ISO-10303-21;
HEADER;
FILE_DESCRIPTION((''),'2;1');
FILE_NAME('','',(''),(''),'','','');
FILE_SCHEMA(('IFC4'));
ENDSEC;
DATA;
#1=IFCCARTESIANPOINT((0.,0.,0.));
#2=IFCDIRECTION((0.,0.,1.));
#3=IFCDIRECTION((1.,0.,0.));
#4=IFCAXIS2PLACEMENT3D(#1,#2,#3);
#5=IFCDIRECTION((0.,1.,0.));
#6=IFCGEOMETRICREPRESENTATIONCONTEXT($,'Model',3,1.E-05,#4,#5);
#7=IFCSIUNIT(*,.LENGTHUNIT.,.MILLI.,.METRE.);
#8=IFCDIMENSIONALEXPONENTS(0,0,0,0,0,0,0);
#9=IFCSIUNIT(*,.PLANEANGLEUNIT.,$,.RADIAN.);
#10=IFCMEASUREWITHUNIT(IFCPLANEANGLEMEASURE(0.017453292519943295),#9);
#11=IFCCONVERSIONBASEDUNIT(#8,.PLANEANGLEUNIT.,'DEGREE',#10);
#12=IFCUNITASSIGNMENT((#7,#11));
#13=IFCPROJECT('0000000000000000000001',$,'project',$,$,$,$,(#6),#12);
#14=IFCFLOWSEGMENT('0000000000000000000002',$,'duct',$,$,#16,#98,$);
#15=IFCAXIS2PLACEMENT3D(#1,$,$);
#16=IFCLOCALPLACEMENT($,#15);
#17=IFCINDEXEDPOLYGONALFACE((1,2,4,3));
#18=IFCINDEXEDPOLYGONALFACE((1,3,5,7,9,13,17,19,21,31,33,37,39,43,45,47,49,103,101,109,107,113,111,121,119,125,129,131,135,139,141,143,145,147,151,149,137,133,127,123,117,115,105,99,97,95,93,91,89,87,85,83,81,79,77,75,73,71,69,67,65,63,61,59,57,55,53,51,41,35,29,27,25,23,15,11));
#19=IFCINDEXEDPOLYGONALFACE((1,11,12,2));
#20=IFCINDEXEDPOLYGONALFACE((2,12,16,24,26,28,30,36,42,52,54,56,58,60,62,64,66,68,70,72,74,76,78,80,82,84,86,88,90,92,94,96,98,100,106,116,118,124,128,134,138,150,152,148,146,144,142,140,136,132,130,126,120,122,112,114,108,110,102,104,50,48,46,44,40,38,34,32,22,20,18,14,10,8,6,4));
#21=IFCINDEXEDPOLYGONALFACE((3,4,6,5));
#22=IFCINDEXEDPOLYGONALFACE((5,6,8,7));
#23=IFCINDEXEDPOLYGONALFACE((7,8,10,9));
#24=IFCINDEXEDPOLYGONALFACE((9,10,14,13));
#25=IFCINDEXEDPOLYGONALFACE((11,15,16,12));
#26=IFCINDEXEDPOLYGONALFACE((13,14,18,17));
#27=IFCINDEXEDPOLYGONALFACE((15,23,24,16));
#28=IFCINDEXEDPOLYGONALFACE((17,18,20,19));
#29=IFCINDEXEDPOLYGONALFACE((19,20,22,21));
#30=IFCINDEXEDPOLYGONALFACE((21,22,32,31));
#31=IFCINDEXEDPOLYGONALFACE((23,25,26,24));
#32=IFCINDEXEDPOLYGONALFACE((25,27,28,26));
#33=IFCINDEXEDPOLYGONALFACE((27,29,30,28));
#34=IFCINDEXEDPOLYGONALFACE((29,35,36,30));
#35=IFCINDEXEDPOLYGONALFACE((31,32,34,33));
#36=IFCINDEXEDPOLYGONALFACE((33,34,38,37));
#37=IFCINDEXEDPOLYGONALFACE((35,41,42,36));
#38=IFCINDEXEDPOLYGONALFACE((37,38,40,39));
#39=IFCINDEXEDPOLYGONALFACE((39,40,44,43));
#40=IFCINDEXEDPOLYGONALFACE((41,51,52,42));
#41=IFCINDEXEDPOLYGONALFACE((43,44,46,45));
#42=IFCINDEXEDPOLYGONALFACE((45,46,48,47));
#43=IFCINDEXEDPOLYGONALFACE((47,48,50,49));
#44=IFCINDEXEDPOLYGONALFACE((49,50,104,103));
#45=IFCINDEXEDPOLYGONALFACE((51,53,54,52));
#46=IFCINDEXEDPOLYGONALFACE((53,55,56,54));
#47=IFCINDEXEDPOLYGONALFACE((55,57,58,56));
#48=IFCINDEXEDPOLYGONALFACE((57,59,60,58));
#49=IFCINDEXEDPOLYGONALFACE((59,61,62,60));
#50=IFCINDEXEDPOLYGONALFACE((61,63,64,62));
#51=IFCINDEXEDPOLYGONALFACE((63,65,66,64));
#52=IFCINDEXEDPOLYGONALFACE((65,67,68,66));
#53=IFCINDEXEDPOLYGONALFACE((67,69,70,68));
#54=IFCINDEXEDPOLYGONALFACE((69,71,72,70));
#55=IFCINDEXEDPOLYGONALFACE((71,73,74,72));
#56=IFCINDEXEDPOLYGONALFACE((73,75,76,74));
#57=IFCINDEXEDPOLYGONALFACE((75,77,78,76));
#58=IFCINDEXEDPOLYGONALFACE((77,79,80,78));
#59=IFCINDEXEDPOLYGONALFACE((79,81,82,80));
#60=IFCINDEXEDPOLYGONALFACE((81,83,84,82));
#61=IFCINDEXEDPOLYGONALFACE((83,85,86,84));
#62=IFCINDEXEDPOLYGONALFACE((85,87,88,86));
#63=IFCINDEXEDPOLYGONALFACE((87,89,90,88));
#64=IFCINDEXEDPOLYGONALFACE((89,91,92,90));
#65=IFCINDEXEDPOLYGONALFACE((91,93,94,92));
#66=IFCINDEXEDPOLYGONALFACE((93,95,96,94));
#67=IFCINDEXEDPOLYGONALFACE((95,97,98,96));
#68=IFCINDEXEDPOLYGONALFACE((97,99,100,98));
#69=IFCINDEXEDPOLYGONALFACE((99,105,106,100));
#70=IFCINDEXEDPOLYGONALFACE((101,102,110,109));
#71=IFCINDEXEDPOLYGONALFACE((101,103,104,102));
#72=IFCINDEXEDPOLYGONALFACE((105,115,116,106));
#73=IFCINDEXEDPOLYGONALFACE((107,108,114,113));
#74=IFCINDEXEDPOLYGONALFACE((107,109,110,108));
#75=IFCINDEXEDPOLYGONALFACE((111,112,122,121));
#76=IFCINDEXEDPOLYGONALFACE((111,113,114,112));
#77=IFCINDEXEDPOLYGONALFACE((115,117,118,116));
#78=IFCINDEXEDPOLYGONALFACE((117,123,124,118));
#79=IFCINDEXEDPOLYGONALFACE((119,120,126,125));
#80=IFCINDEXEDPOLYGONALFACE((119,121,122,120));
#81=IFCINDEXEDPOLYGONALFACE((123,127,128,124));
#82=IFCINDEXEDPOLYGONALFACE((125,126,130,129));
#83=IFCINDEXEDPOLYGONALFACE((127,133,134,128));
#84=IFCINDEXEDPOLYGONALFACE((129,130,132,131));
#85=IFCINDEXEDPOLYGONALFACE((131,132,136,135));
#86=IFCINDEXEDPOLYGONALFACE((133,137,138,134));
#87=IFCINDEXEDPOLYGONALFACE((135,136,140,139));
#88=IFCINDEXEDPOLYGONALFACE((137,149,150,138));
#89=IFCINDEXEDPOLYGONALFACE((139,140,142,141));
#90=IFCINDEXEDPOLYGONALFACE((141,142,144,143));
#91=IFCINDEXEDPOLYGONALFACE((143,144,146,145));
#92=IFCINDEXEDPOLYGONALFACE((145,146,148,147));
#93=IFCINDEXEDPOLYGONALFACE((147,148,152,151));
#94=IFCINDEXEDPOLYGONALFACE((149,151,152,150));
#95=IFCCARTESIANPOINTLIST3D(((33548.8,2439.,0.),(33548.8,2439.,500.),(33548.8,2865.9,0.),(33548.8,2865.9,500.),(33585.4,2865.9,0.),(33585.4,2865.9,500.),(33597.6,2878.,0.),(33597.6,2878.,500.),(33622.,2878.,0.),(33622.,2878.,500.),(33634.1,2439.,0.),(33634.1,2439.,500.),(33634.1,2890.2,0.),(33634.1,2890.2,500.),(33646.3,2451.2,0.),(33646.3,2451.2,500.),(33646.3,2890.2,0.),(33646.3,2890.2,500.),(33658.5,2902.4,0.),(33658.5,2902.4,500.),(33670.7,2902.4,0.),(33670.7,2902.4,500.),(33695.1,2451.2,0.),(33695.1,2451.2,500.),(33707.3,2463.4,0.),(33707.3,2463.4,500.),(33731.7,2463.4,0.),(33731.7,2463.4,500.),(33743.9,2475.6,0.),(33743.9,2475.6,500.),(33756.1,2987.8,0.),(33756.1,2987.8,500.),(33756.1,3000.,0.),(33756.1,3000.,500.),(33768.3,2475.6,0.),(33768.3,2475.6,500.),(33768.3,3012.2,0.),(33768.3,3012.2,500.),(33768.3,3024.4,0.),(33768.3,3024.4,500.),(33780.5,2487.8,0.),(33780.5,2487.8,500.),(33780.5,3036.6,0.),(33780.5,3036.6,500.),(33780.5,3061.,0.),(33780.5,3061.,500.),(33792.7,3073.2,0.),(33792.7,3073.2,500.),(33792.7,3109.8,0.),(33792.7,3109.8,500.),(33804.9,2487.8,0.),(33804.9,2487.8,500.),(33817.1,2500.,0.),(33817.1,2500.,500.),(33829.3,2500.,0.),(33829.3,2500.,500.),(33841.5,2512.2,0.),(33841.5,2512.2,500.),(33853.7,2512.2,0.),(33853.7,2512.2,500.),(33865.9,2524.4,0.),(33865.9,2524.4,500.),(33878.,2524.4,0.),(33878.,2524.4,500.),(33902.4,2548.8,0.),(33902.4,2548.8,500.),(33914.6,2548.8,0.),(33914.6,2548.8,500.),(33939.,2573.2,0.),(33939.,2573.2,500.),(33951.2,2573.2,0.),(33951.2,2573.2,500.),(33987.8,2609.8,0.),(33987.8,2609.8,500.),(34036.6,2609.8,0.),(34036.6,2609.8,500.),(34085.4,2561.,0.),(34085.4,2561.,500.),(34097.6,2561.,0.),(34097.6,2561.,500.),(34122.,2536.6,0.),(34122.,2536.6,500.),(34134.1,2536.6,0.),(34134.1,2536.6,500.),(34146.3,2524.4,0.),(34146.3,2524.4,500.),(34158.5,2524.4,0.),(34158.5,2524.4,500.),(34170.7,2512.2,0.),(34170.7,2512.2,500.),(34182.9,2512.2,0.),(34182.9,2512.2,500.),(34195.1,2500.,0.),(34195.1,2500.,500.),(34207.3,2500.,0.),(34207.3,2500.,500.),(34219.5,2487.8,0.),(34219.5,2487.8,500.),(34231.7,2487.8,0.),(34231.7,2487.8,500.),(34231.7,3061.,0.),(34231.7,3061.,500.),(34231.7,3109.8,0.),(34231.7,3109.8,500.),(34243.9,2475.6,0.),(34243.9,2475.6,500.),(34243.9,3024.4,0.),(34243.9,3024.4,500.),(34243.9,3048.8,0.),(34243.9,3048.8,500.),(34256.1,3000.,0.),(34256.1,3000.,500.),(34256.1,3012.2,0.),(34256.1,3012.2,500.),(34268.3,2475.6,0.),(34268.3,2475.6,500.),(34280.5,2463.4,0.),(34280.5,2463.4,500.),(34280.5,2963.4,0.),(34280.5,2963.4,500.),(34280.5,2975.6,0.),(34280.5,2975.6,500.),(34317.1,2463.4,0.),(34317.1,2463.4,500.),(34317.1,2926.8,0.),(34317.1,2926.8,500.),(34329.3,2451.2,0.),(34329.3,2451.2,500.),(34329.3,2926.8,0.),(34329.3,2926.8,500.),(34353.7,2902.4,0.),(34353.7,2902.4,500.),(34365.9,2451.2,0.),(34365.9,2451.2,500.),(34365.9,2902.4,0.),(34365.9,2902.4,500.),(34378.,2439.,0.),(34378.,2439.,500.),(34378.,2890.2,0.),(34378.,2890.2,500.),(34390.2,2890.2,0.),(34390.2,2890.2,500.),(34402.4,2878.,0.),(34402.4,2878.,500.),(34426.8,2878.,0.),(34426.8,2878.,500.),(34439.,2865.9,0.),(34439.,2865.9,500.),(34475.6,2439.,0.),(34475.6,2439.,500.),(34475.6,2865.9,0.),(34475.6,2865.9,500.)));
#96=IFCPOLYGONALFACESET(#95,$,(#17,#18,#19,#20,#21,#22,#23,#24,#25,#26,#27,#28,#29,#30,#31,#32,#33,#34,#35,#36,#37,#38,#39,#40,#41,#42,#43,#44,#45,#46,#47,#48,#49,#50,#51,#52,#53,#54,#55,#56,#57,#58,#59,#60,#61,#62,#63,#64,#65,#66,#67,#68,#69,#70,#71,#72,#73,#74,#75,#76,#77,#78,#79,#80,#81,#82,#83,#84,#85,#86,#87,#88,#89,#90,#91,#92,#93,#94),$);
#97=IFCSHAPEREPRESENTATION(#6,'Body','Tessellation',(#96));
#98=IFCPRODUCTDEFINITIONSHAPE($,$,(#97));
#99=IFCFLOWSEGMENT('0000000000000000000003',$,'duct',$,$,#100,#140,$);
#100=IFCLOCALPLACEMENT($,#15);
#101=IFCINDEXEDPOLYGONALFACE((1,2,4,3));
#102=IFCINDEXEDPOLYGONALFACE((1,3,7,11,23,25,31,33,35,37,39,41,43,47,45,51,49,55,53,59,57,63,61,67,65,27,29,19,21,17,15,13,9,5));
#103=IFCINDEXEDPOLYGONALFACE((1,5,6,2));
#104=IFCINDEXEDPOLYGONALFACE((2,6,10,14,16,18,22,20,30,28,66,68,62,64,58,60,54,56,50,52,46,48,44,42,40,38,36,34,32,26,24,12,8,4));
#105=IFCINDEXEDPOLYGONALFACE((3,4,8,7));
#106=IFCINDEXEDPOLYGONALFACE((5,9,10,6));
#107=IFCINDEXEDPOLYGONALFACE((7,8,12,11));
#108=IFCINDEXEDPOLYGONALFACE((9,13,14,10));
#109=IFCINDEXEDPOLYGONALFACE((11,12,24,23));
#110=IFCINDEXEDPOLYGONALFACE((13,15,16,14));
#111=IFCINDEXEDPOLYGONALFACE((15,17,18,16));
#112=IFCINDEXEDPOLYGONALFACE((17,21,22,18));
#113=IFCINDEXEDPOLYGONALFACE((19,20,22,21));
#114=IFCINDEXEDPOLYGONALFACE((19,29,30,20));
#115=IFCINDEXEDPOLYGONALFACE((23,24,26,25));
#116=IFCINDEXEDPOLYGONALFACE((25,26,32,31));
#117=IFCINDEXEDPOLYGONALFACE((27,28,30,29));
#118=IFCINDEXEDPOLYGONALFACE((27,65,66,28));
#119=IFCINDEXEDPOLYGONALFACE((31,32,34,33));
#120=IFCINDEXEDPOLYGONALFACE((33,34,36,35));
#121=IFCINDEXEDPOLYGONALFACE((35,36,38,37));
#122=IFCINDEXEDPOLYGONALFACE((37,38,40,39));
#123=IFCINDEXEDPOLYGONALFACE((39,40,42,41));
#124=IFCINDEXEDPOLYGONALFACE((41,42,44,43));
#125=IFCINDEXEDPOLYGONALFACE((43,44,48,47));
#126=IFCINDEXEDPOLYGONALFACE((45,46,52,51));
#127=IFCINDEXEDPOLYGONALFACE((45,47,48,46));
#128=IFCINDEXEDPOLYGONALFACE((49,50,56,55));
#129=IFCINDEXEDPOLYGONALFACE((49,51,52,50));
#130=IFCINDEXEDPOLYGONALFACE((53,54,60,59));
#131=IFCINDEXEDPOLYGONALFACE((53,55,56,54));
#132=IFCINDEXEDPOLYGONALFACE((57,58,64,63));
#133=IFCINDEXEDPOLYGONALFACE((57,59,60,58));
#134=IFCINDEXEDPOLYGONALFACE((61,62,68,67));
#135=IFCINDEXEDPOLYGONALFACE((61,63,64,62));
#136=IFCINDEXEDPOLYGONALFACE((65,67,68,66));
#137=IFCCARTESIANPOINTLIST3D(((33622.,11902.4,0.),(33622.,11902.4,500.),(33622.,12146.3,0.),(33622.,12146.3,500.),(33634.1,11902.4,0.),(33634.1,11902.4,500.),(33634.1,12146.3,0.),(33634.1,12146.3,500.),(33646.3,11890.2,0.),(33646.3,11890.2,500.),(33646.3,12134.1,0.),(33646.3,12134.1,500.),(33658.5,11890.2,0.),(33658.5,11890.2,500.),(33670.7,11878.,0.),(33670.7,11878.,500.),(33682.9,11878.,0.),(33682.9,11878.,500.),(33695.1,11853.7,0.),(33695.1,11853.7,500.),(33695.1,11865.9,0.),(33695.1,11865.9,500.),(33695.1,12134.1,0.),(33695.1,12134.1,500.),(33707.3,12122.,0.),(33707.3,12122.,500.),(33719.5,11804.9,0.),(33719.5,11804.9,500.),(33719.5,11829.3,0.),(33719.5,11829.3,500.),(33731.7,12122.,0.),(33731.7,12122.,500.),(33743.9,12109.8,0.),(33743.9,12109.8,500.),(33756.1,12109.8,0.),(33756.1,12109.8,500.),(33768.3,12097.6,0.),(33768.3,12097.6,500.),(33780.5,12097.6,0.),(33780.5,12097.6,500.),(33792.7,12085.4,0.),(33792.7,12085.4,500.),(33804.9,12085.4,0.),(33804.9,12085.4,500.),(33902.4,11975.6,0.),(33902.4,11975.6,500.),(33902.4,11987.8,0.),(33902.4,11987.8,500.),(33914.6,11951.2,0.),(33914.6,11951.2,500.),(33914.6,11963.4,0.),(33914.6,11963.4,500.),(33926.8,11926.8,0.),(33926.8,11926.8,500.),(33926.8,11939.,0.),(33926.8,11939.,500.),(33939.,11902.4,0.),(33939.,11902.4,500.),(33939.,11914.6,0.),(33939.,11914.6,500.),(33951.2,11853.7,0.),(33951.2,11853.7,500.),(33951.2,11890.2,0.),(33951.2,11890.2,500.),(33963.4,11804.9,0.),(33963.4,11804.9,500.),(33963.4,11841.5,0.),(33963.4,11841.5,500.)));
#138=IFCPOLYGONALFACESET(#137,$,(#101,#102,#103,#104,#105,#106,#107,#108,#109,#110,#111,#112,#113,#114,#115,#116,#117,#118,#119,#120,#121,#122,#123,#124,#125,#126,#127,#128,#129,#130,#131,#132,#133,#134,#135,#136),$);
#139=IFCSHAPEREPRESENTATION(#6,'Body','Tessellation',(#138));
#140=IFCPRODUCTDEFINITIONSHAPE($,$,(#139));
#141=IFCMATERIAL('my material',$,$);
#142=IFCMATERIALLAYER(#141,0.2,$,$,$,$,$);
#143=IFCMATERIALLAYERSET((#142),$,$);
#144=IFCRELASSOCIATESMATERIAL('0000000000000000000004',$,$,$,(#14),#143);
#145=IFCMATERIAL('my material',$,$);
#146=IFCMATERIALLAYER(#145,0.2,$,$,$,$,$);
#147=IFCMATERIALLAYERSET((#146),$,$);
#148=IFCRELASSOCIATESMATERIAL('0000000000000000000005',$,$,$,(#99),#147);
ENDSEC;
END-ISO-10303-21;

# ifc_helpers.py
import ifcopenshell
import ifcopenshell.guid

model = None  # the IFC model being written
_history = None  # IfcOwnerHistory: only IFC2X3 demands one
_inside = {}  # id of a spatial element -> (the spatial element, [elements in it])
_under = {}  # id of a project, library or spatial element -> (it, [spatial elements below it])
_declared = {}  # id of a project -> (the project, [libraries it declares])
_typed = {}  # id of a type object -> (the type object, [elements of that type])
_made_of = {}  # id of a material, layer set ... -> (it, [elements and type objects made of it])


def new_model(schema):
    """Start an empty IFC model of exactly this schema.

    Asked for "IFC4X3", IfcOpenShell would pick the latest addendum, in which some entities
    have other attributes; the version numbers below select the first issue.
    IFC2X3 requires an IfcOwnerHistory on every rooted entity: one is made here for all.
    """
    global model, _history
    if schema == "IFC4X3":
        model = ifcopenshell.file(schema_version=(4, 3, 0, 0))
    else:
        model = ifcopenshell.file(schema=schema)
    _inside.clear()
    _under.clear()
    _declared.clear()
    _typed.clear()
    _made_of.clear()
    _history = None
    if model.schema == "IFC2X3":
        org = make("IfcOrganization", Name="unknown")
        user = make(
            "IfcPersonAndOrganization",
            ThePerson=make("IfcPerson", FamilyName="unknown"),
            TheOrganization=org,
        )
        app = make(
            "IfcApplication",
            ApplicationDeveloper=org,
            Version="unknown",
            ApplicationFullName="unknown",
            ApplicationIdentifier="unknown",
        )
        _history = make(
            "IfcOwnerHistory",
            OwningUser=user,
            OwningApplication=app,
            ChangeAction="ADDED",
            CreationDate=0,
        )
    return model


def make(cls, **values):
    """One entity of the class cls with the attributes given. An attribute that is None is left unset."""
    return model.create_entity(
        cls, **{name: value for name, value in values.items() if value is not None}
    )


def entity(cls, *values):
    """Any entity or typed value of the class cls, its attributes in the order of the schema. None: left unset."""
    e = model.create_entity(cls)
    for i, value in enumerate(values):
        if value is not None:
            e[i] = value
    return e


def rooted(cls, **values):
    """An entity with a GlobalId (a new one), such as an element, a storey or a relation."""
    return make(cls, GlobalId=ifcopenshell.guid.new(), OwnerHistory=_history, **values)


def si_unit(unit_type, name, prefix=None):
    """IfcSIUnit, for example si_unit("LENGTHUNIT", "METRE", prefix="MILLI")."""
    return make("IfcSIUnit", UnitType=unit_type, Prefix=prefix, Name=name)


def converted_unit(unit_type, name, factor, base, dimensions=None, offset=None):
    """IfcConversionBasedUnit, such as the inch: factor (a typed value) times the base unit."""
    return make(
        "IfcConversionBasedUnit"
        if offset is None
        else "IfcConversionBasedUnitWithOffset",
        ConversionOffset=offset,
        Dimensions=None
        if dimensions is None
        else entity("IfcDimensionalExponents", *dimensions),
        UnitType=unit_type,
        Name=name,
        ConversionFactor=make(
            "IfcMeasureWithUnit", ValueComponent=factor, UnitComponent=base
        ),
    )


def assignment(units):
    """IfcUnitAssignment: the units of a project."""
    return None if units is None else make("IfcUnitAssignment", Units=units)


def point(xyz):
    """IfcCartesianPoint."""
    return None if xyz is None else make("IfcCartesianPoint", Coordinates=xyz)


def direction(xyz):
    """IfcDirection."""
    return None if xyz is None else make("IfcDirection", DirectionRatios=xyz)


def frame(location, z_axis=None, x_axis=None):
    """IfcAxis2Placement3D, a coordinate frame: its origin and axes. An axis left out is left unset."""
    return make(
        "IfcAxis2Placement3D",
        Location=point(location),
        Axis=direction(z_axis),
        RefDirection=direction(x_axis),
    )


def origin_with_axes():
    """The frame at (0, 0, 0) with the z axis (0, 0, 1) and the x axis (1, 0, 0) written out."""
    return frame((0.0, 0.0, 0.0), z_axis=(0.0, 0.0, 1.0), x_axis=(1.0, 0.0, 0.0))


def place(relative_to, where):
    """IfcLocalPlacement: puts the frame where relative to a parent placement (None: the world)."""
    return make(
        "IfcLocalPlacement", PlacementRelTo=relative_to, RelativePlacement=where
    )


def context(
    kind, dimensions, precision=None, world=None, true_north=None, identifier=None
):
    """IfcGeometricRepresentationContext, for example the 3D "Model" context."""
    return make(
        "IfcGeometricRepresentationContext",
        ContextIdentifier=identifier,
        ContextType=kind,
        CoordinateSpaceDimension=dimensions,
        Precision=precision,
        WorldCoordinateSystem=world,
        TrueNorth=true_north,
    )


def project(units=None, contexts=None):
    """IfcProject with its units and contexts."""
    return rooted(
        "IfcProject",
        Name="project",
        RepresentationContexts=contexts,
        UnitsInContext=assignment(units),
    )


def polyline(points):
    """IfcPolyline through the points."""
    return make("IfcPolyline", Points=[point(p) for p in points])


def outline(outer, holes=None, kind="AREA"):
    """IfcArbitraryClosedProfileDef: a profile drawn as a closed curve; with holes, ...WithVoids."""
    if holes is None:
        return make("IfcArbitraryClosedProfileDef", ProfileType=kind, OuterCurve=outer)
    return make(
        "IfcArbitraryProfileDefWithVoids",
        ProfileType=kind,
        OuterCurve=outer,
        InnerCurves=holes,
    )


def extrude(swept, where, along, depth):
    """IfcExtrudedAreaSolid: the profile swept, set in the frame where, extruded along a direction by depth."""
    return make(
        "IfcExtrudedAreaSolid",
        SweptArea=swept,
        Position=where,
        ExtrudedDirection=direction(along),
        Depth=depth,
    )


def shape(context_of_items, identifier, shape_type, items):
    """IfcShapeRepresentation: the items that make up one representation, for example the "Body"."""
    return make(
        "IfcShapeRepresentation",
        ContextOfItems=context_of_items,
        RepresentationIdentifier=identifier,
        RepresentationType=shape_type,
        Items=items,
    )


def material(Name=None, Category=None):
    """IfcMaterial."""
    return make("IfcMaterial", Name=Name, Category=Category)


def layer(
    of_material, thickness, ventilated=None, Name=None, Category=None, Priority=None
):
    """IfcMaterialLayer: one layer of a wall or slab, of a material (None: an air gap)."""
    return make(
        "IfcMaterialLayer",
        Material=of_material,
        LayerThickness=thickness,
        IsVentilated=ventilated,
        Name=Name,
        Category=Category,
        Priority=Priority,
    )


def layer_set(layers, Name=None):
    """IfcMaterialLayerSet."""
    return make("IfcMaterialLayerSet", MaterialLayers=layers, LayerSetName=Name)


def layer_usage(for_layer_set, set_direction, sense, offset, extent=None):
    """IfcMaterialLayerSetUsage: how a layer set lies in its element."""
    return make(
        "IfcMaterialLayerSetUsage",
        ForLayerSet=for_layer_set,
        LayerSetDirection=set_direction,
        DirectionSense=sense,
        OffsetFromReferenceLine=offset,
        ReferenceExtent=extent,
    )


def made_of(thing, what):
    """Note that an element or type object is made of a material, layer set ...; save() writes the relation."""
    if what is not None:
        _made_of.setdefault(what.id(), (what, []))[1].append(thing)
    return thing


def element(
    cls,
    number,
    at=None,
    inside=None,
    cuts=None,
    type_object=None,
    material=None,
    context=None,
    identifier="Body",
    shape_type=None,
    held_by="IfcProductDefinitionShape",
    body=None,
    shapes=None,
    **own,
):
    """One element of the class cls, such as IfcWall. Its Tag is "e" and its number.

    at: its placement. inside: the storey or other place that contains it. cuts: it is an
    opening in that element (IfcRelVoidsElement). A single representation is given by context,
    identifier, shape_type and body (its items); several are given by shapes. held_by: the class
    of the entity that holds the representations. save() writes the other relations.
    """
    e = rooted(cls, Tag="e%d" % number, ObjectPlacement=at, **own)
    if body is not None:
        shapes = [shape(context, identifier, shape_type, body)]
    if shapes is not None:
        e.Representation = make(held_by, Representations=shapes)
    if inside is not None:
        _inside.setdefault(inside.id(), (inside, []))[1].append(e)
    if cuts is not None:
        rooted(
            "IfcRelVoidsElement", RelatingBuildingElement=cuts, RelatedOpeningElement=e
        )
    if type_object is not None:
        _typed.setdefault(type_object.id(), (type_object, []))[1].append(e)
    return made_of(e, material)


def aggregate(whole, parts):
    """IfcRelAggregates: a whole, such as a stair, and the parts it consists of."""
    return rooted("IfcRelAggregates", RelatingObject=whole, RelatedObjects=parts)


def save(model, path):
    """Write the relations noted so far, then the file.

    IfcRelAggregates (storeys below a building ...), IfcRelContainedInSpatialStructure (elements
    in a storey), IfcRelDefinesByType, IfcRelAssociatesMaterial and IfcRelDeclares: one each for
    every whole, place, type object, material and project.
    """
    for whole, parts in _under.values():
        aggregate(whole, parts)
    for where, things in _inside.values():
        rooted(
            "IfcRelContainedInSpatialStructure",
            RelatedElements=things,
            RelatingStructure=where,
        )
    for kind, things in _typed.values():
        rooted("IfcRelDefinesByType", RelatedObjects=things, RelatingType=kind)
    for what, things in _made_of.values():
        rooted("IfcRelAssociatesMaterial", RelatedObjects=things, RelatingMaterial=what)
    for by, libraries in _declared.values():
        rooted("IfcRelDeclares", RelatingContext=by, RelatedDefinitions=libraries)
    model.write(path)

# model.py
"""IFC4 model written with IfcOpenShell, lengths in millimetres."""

from ifc_helpers import new_model, entity, si_unit, converted_unit, direction, origin_with_axes, place, context, project, polyline, outline, extrude, material, layer, layer_set, layer_usage, element, save


model = new_model("IFC4")

# Units and contexts
model_context = context("Model", 3, precision=1e-05, world=origin_with_axes(), true_north=direction((0.0, 1.0, 0.0)))
ifc_project = project(units=[si_unit("LENGTHUNIT", "METRE", prefix="MILLI"), converted_unit("PLANEANGLEUNIT", "DEGREE", entity("IfcPlaneAngleMeasure", 0.017453292519943295), si_unit("PLANEANGLEUNIT", "RADIAN"), dimensions=[0, 0, 0, 0, 0, 0, 0])], contexts=[model_context])

# Flow segments
ifc_material_1 = material(Name="my material")
ifc_layer_1 = layer(ifc_material_1, 0.2)
ifc_layer_set_1 = layer_set([ifc_layer_1])
ifc_layer_usage_1 = layer_usage(ifc_layer_set_1, "AXIS2", "POSITIVE", -0.1)
flow_segment_1_placement = place(None, origin_with_axes())
element("IfcFlowSegment", 1, at=flow_segment_1_placement, material=ifc_layer_usage_1, Name="duct", context=model_context, shape_type="SweptSolid", body=[
    extrude(outline(polyline([(33548.8, 2439.0), (33634.1, 2439.0), (33646.3, 2451.2), (33695.1, 2451.2), (33707.3, 2463.4), (33731.7, 2463.4), (33743.9, 2475.6), (33768.3, 2475.6), (33780.5, 2487.8), (33804.9, 2487.8), (33817.1, 2500.0), (33829.3, 2500.0), (33841.5, 2512.2), (33853.7, 2512.2), (33865.9, 2524.4), (33878.0, 2524.4), (33902.4, 2548.8), (33914.6, 2548.8), (33939.0, 2573.2), (33951.2, 2573.2), (33987.8, 2609.8), (34036.6, 2609.8), (34085.4, 2561.0), (34097.6, 2561.0), (34122.0, 2536.6), (34134.1, 2536.6), (34146.3, 2524.4), (34158.5, 2524.4), (34170.7, 2512.2), (34182.9, 2512.2), (34195.1, 2500.0), (34207.3, 2500.0), (34219.5, 2487.8), (34231.7, 2487.8), (34243.9, 2475.6), (34268.3, 2475.6), (34280.5, 2463.4), (34317.1, 2463.4), (34329.3, 2451.2), (34365.9, 2451.2), (34378.0, 2439.0), (34475.6, 2439.0), (34475.6, 2865.9), (34439.0, 2865.9), (34426.8, 2878.0), (34402.4, 2878.0), (34390.2, 2890.2), (34378.0, 2890.2), (34365.9, 2902.4), (34353.7, 2902.4), (34329.3, 2926.8), (34317.1, 2926.8), (34280.5, 2963.4), (34280.5, 2975.6), (34256.1, 3000.0), (34256.1, 3012.2), (34243.9, 3024.4), (34243.9, 3048.8), (34231.7, 3061.0), (34231.7, 3109.8), (33792.7, 3109.8), (33792.7, 3073.2), (33780.5, 3061.0), (33780.5, 3036.6), (33768.3, 3024.4), (33768.3, 3012.2), (33756.1, 3000.0), (33756.1, 2987.8), (33670.7, 2902.4), (33658.5, 2902.4), (33646.3, 2890.2), (33634.1, 2890.2), (33622.0, 2878.0), (33597.6, 2878.0), (33585.4, 2865.9), (33548.8, 2865.9), (33548.8, 2439.0)])), origin_with_axes(), (0.0, 0.0, 1.0), 500.0),
])
ifc_material_2 = material(Name="my material")
ifc_layer_2 = layer(ifc_material_2, 0.2)
ifc_layer_set_2 = layer_set([ifc_layer_2])
ifc_layer_usage_2 = layer_usage(ifc_layer_set_2, "AXIS2", "POSITIVE", -0.1)
flow_segment_2_placement = place(None, origin_with_axes())
element("IfcFlowSegment", 2, at=flow_segment_2_placement, material=ifc_layer_usage_2, Name="duct", context=model_context, shape_type="SweptSolid", body=[
    extrude(outline(polyline([(33622.0, 11902.4), (33634.1, 11902.4), (33646.3, 11890.2), (33658.5, 11890.2), (33670.7, 11878.0), (33682.9, 11878.0), (33695.1, 11865.9), (33695.1, 11853.7), (33719.5, 11829.3), (33719.5, 11804.9), (33963.4, 11804.9), (33963.4, 11841.5), (33951.2, 11853.7), (33951.2, 11890.2), (33939.0, 11902.4), (33939.0, 11914.6), (33926.8, 11926.8), (33926.8, 11939.0), (33914.6, 11951.2), (33914.6, 11963.4), (33902.4, 11975.6), (33902.4, 11987.8), (33804.9, 12085.4), (33792.7, 12085.4), (33780.5, 12097.6), (33768.3, 12097.6), (33756.1, 12109.8), (33743.9, 12109.8), (33731.7, 12122.0), (33707.3, 12122.0), (33695.1, 12134.1), (33646.3, 12134.1), (33634.1, 12146.3), (33622.0, 12146.3), (33622.0, 11902.4)])), origin_with_axes(), (0.0, 0.0, 1.0), 500.0),
])

save(model, "model.ifc")
